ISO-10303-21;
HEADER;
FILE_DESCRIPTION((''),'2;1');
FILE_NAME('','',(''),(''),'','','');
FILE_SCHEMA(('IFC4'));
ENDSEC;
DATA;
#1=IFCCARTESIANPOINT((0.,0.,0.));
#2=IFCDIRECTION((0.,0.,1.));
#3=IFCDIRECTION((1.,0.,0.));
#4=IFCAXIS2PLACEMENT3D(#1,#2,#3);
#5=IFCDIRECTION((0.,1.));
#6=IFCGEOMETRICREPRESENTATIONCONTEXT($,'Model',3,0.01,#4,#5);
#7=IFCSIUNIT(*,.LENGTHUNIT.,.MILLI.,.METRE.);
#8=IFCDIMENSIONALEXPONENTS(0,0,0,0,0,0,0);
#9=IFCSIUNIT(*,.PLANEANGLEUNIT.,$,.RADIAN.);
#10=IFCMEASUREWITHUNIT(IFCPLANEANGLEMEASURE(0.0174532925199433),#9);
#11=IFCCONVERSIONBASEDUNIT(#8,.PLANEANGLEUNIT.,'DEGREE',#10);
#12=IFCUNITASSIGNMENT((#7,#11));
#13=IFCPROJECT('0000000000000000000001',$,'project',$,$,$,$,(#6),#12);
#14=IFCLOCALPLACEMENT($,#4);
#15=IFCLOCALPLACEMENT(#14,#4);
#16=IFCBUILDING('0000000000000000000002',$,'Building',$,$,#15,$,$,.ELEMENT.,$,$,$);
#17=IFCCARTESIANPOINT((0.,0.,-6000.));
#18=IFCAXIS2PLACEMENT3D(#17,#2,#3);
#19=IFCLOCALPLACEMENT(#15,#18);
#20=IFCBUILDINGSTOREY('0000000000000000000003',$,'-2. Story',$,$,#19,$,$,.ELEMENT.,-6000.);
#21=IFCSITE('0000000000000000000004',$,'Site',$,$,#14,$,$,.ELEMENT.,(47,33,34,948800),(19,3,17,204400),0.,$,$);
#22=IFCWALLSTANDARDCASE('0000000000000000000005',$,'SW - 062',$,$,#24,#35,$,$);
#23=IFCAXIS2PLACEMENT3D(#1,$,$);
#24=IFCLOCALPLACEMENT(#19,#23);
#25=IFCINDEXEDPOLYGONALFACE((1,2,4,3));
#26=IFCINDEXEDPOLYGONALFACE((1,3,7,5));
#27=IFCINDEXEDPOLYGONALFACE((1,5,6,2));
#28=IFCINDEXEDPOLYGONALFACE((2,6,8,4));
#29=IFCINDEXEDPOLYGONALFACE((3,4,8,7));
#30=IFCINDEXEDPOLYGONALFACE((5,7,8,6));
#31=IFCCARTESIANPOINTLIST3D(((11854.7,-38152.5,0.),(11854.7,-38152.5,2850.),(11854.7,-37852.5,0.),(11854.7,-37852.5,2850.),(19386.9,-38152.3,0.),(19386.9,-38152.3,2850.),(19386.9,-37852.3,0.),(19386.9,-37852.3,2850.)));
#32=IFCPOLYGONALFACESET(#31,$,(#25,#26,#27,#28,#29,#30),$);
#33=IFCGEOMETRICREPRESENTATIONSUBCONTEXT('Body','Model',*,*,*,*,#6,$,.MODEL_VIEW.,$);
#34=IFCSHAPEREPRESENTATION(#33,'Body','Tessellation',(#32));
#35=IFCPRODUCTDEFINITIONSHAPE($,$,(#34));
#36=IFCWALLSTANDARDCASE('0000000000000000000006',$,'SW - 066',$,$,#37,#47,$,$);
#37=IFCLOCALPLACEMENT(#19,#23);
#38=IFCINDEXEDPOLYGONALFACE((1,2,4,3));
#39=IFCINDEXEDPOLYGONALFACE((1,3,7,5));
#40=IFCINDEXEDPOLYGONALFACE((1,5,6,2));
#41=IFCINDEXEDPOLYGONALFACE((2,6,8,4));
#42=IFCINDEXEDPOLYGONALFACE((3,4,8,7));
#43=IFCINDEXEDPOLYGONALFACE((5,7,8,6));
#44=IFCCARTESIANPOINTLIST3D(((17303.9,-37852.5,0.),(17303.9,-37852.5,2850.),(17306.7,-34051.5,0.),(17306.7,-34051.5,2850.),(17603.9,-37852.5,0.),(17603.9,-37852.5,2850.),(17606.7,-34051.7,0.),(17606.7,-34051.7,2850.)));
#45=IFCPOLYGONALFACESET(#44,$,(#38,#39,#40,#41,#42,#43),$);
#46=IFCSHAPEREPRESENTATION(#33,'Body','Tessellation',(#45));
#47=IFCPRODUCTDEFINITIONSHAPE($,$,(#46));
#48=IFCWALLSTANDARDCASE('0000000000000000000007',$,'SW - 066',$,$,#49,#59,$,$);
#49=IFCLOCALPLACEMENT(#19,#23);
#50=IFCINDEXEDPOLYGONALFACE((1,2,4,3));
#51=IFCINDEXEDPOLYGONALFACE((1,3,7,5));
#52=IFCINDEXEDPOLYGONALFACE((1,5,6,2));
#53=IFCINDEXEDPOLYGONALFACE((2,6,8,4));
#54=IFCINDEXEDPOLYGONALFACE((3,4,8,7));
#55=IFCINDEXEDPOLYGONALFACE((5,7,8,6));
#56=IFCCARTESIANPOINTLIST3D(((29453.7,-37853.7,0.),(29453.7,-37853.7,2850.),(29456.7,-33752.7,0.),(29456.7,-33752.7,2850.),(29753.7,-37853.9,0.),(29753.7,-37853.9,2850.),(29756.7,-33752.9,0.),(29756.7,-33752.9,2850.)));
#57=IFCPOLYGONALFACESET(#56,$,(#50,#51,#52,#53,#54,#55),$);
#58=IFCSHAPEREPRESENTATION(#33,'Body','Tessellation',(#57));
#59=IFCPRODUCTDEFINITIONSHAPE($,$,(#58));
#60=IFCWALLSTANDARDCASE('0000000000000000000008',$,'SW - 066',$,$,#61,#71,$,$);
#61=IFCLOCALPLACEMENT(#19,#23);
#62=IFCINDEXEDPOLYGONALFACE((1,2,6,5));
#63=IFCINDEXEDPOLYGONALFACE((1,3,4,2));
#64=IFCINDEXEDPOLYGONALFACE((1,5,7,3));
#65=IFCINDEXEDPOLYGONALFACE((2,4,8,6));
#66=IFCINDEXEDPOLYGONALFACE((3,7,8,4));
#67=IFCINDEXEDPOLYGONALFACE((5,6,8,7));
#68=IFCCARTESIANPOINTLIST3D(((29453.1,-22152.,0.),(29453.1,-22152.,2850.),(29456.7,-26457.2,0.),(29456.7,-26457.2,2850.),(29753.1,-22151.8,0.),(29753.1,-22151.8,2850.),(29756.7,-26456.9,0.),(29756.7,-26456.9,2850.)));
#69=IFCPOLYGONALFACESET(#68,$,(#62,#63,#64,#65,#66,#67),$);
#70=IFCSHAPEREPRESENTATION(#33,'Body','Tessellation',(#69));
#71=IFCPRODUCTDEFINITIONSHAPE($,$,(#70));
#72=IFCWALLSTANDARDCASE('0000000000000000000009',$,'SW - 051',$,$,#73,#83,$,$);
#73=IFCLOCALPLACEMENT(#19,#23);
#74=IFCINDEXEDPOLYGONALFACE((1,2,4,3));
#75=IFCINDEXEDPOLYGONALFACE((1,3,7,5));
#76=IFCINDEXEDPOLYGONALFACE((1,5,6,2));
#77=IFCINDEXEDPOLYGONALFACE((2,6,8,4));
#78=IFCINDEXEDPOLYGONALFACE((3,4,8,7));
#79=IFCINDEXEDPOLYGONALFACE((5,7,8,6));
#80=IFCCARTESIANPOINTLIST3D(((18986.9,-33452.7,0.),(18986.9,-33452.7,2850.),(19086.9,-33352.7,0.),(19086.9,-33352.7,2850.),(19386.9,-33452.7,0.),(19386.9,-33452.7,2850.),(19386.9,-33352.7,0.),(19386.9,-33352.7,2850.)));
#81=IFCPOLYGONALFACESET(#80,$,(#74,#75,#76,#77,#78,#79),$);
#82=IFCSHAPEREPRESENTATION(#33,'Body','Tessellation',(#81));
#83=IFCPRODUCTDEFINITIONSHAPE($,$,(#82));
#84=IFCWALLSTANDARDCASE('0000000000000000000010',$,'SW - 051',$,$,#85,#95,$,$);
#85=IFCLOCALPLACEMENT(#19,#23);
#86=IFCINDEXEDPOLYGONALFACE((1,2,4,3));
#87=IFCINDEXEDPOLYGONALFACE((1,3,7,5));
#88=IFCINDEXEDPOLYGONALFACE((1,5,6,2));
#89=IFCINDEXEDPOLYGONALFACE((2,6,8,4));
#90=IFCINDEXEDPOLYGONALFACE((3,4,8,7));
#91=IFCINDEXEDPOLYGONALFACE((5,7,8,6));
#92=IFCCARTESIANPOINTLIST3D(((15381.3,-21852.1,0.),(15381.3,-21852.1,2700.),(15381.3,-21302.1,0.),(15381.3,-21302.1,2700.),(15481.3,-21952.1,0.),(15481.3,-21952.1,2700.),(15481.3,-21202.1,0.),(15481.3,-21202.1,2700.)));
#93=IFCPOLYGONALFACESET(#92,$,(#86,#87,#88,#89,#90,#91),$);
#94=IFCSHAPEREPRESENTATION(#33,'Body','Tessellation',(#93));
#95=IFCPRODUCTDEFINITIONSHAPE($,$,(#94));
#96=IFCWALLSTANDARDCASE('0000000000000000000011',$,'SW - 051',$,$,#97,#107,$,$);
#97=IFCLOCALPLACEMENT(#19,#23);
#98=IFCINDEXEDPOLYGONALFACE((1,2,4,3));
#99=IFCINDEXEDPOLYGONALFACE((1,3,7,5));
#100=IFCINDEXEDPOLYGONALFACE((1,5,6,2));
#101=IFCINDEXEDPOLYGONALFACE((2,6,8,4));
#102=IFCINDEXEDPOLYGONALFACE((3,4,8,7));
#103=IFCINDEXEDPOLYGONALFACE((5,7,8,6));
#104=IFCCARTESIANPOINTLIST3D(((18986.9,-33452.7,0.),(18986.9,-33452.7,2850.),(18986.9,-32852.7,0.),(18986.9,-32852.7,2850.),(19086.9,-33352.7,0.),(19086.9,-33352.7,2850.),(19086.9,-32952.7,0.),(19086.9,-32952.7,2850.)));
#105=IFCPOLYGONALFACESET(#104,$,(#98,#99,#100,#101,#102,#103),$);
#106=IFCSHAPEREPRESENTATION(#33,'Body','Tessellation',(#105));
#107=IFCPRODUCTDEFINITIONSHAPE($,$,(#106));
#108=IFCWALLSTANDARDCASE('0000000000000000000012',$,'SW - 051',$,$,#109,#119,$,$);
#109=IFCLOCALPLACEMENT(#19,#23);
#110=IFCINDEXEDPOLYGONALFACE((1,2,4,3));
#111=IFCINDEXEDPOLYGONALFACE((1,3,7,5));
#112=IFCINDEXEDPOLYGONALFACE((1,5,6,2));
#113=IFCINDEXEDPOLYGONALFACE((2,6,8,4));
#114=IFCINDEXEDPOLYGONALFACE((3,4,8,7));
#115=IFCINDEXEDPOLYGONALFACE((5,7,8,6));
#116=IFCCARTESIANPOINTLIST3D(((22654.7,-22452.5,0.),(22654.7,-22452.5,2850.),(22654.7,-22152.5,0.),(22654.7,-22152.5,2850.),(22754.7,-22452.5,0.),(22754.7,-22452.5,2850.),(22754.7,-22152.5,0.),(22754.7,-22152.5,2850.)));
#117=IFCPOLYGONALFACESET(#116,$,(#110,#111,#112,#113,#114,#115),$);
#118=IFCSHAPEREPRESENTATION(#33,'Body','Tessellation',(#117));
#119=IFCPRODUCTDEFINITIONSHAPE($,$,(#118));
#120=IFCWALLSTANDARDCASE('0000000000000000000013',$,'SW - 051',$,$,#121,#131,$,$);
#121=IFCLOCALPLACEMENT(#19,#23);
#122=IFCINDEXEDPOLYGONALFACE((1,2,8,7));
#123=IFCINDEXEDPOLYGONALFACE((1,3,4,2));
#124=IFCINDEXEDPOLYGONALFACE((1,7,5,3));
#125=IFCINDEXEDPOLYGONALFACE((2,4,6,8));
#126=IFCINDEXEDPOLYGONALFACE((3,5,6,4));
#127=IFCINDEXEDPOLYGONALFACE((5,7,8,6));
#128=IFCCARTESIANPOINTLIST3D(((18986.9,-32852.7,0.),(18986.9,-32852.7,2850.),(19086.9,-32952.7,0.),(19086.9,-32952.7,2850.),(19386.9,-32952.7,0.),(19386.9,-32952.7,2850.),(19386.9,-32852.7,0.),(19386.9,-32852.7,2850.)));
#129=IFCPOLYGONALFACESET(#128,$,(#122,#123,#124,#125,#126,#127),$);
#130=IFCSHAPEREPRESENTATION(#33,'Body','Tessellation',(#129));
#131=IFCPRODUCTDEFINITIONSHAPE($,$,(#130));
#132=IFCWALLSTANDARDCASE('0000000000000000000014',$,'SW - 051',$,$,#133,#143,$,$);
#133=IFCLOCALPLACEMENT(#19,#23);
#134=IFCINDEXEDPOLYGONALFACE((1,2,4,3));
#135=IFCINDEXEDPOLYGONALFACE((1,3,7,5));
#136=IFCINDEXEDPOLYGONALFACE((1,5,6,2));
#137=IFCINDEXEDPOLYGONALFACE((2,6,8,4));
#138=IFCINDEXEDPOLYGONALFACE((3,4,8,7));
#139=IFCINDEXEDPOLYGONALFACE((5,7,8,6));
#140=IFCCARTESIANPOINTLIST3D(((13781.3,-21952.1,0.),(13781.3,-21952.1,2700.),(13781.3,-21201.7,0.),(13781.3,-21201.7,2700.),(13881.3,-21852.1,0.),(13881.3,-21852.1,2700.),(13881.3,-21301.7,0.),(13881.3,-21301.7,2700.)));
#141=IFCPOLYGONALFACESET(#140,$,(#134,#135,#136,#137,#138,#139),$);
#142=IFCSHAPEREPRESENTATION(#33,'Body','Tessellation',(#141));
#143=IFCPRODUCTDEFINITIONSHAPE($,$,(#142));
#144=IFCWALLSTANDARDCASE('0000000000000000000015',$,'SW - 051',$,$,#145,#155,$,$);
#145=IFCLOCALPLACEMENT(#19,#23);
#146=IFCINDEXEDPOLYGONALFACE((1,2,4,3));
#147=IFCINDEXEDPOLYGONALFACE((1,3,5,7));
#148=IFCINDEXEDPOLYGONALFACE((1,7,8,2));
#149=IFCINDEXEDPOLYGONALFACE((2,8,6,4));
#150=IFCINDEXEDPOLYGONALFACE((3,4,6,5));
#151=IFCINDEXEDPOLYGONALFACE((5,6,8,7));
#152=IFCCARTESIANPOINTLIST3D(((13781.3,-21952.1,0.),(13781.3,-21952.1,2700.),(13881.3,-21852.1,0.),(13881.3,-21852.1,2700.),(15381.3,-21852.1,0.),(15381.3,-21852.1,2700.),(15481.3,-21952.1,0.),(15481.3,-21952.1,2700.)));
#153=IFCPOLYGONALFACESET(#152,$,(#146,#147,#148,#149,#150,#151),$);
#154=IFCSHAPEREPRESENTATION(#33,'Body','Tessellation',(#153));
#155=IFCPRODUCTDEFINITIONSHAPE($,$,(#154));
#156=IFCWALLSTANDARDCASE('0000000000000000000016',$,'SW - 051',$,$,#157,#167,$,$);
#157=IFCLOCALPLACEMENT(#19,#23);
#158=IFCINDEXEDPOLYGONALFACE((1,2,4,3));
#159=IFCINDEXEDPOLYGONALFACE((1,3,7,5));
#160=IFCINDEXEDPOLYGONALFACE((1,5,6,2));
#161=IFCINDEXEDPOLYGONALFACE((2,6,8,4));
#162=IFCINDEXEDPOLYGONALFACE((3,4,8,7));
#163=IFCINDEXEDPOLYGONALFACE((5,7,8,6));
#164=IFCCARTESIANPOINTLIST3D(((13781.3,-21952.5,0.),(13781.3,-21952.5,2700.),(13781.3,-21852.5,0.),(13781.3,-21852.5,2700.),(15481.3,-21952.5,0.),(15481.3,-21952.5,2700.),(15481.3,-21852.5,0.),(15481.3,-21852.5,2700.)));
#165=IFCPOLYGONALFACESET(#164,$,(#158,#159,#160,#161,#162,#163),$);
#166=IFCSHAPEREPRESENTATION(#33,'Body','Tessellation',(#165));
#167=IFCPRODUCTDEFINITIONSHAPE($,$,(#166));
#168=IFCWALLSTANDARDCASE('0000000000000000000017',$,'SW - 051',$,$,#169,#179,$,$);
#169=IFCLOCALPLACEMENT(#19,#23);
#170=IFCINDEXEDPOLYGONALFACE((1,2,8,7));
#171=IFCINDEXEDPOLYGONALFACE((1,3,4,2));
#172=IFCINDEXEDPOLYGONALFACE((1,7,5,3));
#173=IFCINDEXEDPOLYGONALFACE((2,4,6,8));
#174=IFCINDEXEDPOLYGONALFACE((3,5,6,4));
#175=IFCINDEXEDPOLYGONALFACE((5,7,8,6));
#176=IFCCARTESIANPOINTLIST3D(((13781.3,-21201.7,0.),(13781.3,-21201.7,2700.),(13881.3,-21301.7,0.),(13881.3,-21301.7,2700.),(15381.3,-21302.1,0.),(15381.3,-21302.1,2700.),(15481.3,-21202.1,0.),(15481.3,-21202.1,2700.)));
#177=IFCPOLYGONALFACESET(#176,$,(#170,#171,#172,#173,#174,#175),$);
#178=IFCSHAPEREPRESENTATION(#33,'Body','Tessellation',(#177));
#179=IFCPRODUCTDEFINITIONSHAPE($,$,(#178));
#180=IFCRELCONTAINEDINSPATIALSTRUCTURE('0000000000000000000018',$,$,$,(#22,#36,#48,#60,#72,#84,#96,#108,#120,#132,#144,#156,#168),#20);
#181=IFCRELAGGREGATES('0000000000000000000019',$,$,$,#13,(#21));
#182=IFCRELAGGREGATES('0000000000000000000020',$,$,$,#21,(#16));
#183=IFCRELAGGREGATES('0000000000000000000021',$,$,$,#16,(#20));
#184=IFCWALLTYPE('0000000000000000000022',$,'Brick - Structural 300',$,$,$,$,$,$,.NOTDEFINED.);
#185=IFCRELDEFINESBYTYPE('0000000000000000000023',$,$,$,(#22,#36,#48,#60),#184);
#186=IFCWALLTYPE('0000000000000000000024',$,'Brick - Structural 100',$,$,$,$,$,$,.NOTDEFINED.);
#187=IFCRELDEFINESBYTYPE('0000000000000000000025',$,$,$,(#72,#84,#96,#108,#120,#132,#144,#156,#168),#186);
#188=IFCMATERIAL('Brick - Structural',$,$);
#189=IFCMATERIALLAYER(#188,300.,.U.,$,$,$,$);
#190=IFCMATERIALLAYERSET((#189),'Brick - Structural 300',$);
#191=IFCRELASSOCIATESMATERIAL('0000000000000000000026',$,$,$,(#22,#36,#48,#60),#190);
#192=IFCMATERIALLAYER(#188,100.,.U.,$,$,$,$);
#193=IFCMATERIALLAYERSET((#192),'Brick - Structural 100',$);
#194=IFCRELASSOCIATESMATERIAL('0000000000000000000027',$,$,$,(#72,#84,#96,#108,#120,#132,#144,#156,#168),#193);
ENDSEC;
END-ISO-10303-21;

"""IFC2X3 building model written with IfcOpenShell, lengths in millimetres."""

from ifc_helpers import new_model, entity, si_unit, converted_unit, direction, frame, origin_with_axes, place, context, subcontext, project, spatial, polyline, outline, extrude, material, layer, layer_set, layer_usage, type_object, element, save


model = new_model("IFC2X3")

# Units and contexts
model_context = context("Model", 3, precision=0.01, world=origin_with_axes(), true_north=direction((0.0, 1.0)))
body_context = subcontext(model_context, "Body", "Model", "MODEL_VIEW")
ifc_project = project(units=[si_unit("LENGTHUNIT", "METRE", prefix="MILLI"), converted_unit("PLANEANGLEUNIT", "DEGREE", entity("IfcPlaneAngleMeasure", 0.0174532925199433), si_unit("PLANEANGLEUNIT", "RADIAN"), dimensions=[0, 0, 0, 0, 0, 0, 0])], contexts=[model_context])

# Site, building, storey
site_placement = place(None, origin_with_axes())
site = spatial("IfcSite", under=ifc_project, at=site_placement, Name="Site", CompositionType="ELEMENT", RefLatitude=(47, 33, 34, 948800), RefLongitude=(19, 3, 17, 204400), RefElevation=0.0)
building_placement = place(site_placement, origin_with_axes())
building = spatial("IfcBuilding", under=site, at=building_placement, Name="Building", CompositionType="ELEMENT")
storey_placement = place(building_placement, frame((0.0, 0.0, -6000.0), z_axis=(0.0, 0.0, 1.0), x_axis=(1.0, 0.0, 0.0)))
storey = spatial("IfcBuildingStorey", under=building, at=storey_placement, Name="-2. Story", CompositionType="ELEMENT", Elevation=-6000.0)

# Shared definitions
ifc_material_1 = material(Name="Brick - Structural")
ifc_layer_1 = layer(ifc_material_1, 300.0, ventilated="UNKNOWN")
ifc_layer_set_1 = layer_set([ifc_layer_1], Name="Brick - Structural 300")
wall_type_1 = type_object("IfcWallType", Name="Brick - Structural 300", PredefinedType="NOTDEFINED")

# Walls
ifc_layer_usage_1 = layer_usage(ifc_layer_set_1, "AXIS2", "POSITIVE", 0.0)
wall_1_placement = place(storey_placement, frame((11854.7, -38152.5, 0.0), z_axis=(0.0, 0.0, 1.0), x_axis=(1.0, 0.000025, 0.0)))
element("IfcWallStandardCase", 1, at=wall_1_placement, inside=storey, type_object=wall_type_1, material=ifc_layer_usage_1, Name="SW - 062", context=body_context, shape_type="SweptSolid", body=[
    extrude(outline(polyline([(0.0, 0.0), (7532.2, 0.0), (7532.2, 300.0), (0.0, 300.0), (0.0, 0.0)])), origin_with_axes(), (0.0, 0.0, 1.0), 2850.0),
])
ifc_layer_usage_2 = layer_usage(ifc_layer_set_1, "AXIS2", "POSITIVE", 0.0)
wall_2_placement = place(storey_placement, frame((17306.7, -34051.5, 0.0), z_axis=(0.0, 0.0, 1.0), x_axis=(-0.000749, -1.0, 0.0)))
element("IfcWallStandardCase", 2, at=wall_2_placement, inside=storey, type_object=wall_type_1, material=ifc_layer_usage_2, Name="SW - 066", context=body_context, shape_type="SweptSolid", body=[
    extrude(outline(polyline([(0.0, 0.0), (3801.0, 0.0), (3800.8, 300.0), (0.0, 300.0), (0.0, 0.0)])), origin_with_axes(), (0.0, 0.0, 1.0), 2850.0),
])
ifc_layer_usage_3 = layer_usage(ifc_layer_set_1, "AXIS2", "POSITIVE", 0.0)
wall_3_placement = place(storey_placement, frame((29456.7, -33752.7, 0.0), z_axis=(0.0, 0.0, 1.0), x_axis=(-0.000749, -1.0, 0.0)))
element("IfcWallStandardCase", 3, at=wall_3_placement, inside=storey, type_object=wall_type_1, material=ifc_layer_usage_3, Name="SW - 066", context=body_context, shape_type="SweptSolid", body=[
    extrude(outline(polyline([(0.0, 0.0), (4101.0, 0.0), (4101.0, 300.0), (0.0, 300.0), (0.0, 0.0)])), origin_with_axes(), (0.0, 0.0, 1.0), 2850.0),
])
ifc_layer_usage_4 = layer_usage(ifc_layer_set_1, "AXIS2", "POSITIVE", 0.0)
wall_4_placement = place(storey_placement, frame((29453.1, -22152.0, 0.0), z_axis=(0.0, 0.0, 1.0), x_axis=(0.000847, -1.0, 0.0)))
element("IfcWallStandardCase", 4, at=wall_4_placement, inside=storey, type_object=wall_type_1, material=ifc_layer_usage_4, Name="SW - 066", context=body_context, shape_type="SweptSolid", body=[
    extrude(outline(polyline([(0.0, 0.0), (4305.1, 0.0), (4305.1, 300.0), (0.0, 300.0), (0.0, 0.0)])), origin_with_axes(), (0.0, 0.0, 1.0), 2850.0),
])
ifc_layer_2 = layer(ifc_material_1, 100.0, ventilated="UNKNOWN")
ifc_layer_set_2 = layer_set([ifc_layer_2], Name="Brick - Structural 100")
ifc_layer_usage_5 = layer_usage(ifc_layer_set_2, "AXIS2", "POSITIVE", 0.0)
wall_type_2 = type_object("IfcWallType", Name="Brick - Structural 100", PredefinedType="NOTDEFINED")
wall_5_placement = place(storey_placement, frame((19086.9, -33452.7, 0.0), z_axis=(0.0, 0.0, 1.0), x_axis=(1.0, 0.0, 0.0)))
element("IfcWallStandardCase", 5, at=wall_5_placement, inside=storey, type_object=wall_type_2, material=ifc_layer_usage_5, Name="SW - 051", context=body_context, shape_type="SweptSolid", body=[
    extrude(outline(polyline([(-100.0, 0.0), (300.0, 0.0), (300.0, 100.0), (0.0, 100.0), (-100.0, 0.0)])), origin_with_axes(), (0.0, 0.0, 1.0), 2850.0),
])
ifc_layer_usage_6 = layer_usage(ifc_layer_set_2, "AXIS2", "NEGATIVE", 0.0)
wall_6_placement = place(storey_placement, frame((15381.3, -21952.1, 0.0), z_axis=(0.0, 0.0, 1.0), x_axis=(0.0, 1.0, 0.0)))
element("IfcWallStandardCase", 6, at=wall_6_placement, inside=storey, type_object=wall_type_2, material=ifc_layer_usage_6, Name="SW - 051", context=body_context, shape_type="SweptSolid", body=[
    extrude(outline(polyline([(0.0, -100.0), (750.0, -100.0), (650.0, 0.0), (100.0, 0.0), (0.0, -100.0)])), origin_with_axes(), (0.0, 0.0, 1.0), 2700.0),
])
ifc_layer_usage_7 = layer_usage(ifc_layer_set_2, "AXIS2", "POSITIVE", 0.0)
wall_7_placement = place(storey_placement, frame((19086.9, -33452.7, 0.0), z_axis=(0.0, 0.0, 1.0), x_axis=(0.0, 1.0, 0.0)))
element("IfcWallStandardCase", 7, at=wall_7_placement, inside=storey, type_object=wall_type_2, material=ifc_layer_usage_7, Name="SW - 051", context=body_context, shape_type="SweptSolid", body=[
    extrude(outline(polyline([(100.0, 0.0), (500.0, 0.0), (600.0, 100.0), (0.0, 100.0), (100.0, 0.0)])), origin_with_axes(), (0.0, 0.0, 1.0), 2850.0),
])
ifc_layer_usage_8 = layer_usage(ifc_layer_set_2, "AXIS2", "NEGATIVE", 0.0)
wall_8_placement = place(storey_placement, frame((22654.7, -22452.5, 0.0), z_axis=(0.0, 0.0, 1.0), x_axis=(0.0, 1.0, 0.0)))
element("IfcWallStandardCase", 8, at=wall_8_placement, inside=storey, type_object=wall_type_2, material=ifc_layer_usage_8, Name="SW - 051", context=body_context, shape_type="SweptSolid", body=[
    extrude(outline(polyline([(0.0, -100.0), (300.0, -100.0), (300.0, 0.0), (0.0, 0.0), (0.0, -100.0)])), origin_with_axes(), (0.0, 0.0, 1.0), 2850.0),
])
ifc_layer_usage_9 = layer_usage(ifc_layer_set_2, "AXIS2", "POSITIVE", 0.0)
wall_9_placement = place(storey_placement, frame((19086.9, -32952.7, 0.0), z_axis=(0.0, 0.0, 1.0), x_axis=(1.0, 0.0, 0.0)))
element("IfcWallStandardCase", 9, at=wall_9_placement, inside=storey, type_object=wall_type_2, material=ifc_layer_usage_9, Name="SW - 051", context=body_context, shape_type="SweptSolid", body=[
    extrude(outline(polyline([(0.0, 0.0), (300.0, 0.0), (300.0, 100.0), (-100.0, 100.0), (0.0, 0.0)])), origin_with_axes(), (0.0, 0.0, 1.0), 2850.0),
])
ifc_layer_usage_10 = layer_usage(ifc_layer_set_2, "AXIS2", "NEGATIVE", 0.0)
wall_10_placement = place(storey_placement, frame((13781.3, -21952.1, 0.0), z_axis=(0.0, 0.0, 1.0), x_axis=(0.0, 1.0, 0.0)))
element("IfcWallStandardCase", 10, at=wall_10_placement, inside=storey, type_object=wall_type_2, material=ifc_layer_usage_10, Name="SW - 051", context=body_context, shape_type="SweptSolid", body=[
    extrude(outline(polyline([(100.0, -100.0), (650.4, -100.0), (750.4, 0.0), (0.0, 0.0), (100.0, -100.0)])), origin_with_axes(), (0.0, 0.0, 1.0), 2700.0),
])
ifc_layer_usage_11 = layer_usage(ifc_layer_set_2, "AXIS2", "NEGATIVE", 0.0)
wall_11_placement = place(storey_placement, frame((15381.3, -21952.1, 0.0), z_axis=(0.0, 0.0, 1.0), x_axis=(-1.0, 0.0, 0.0)))
element("IfcWallStandardCase", 11, at=wall_11_placement, inside=storey, type_object=wall_type_2, material=ifc_layer_usage_11, Name="SW - 051", context=body_context, shape_type="SweptSolid", body=[
    extrude(outline(polyline([(0.0, -100.0), (1500.0, -100.0), (1600.0, 0.0), (-100.0, 0.0), (0.0, -100.0)])), origin_with_axes(), (0.0, 0.0, 1.0), 2700.0),
])
ifc_layer_usage_12 = layer_usage(ifc_layer_set_2, "AXIS2", "NEGATIVE", 0.0)
wall_12_placement = place(storey_placement, frame((15481.3, -21952.5, 0.0), z_axis=(0.0, 0.0, 1.0), x_axis=(-1.0, 0.0, 0.0)))
element("IfcWallStandardCase", 12, at=wall_12_placement, inside=storey, type_object=wall_type_2, material=ifc_layer_usage_12, Name="SW - 051", context=body_context, shape_type="SweptSolid", body=[
    extrude(outline(polyline([(0.0, -100.0), (1700.0, -100.0), (1700.0, 0.0), (0.0, 0.0), (0.0, -100.0)])), origin_with_axes(), (0.0, 0.0, 1.0), 2700.0),
])
ifc_layer_usage_13 = layer_usage(ifc_layer_set_2, "AXIS2", "NEGATIVE", 0.0)
wall_13_placement = place(storey_placement, frame((15381.3, -21302.1, 0.0), z_axis=(0.0, 0.0, 1.0), x_axis=(-1.0, 0.000256, 0.0)))
element("IfcWallStandardCase", 13, at=wall_13_placement, inside=storey, type_object=wall_type_2, material=ifc_layer_usage_13, Name="SW - 051", context=body_context, shape_type="SweptSolid", body=[
    extrude(outline(polyline([(-100.0, -100.0), (1600.0, -100.0), (1500.0, 0.0), (0.0, 0.0), (-100.0, -100.0)])), origin_with_axes(), (0.0, 0.0, 1.0), 2700.0),
])

save(model, "model.ifc")
